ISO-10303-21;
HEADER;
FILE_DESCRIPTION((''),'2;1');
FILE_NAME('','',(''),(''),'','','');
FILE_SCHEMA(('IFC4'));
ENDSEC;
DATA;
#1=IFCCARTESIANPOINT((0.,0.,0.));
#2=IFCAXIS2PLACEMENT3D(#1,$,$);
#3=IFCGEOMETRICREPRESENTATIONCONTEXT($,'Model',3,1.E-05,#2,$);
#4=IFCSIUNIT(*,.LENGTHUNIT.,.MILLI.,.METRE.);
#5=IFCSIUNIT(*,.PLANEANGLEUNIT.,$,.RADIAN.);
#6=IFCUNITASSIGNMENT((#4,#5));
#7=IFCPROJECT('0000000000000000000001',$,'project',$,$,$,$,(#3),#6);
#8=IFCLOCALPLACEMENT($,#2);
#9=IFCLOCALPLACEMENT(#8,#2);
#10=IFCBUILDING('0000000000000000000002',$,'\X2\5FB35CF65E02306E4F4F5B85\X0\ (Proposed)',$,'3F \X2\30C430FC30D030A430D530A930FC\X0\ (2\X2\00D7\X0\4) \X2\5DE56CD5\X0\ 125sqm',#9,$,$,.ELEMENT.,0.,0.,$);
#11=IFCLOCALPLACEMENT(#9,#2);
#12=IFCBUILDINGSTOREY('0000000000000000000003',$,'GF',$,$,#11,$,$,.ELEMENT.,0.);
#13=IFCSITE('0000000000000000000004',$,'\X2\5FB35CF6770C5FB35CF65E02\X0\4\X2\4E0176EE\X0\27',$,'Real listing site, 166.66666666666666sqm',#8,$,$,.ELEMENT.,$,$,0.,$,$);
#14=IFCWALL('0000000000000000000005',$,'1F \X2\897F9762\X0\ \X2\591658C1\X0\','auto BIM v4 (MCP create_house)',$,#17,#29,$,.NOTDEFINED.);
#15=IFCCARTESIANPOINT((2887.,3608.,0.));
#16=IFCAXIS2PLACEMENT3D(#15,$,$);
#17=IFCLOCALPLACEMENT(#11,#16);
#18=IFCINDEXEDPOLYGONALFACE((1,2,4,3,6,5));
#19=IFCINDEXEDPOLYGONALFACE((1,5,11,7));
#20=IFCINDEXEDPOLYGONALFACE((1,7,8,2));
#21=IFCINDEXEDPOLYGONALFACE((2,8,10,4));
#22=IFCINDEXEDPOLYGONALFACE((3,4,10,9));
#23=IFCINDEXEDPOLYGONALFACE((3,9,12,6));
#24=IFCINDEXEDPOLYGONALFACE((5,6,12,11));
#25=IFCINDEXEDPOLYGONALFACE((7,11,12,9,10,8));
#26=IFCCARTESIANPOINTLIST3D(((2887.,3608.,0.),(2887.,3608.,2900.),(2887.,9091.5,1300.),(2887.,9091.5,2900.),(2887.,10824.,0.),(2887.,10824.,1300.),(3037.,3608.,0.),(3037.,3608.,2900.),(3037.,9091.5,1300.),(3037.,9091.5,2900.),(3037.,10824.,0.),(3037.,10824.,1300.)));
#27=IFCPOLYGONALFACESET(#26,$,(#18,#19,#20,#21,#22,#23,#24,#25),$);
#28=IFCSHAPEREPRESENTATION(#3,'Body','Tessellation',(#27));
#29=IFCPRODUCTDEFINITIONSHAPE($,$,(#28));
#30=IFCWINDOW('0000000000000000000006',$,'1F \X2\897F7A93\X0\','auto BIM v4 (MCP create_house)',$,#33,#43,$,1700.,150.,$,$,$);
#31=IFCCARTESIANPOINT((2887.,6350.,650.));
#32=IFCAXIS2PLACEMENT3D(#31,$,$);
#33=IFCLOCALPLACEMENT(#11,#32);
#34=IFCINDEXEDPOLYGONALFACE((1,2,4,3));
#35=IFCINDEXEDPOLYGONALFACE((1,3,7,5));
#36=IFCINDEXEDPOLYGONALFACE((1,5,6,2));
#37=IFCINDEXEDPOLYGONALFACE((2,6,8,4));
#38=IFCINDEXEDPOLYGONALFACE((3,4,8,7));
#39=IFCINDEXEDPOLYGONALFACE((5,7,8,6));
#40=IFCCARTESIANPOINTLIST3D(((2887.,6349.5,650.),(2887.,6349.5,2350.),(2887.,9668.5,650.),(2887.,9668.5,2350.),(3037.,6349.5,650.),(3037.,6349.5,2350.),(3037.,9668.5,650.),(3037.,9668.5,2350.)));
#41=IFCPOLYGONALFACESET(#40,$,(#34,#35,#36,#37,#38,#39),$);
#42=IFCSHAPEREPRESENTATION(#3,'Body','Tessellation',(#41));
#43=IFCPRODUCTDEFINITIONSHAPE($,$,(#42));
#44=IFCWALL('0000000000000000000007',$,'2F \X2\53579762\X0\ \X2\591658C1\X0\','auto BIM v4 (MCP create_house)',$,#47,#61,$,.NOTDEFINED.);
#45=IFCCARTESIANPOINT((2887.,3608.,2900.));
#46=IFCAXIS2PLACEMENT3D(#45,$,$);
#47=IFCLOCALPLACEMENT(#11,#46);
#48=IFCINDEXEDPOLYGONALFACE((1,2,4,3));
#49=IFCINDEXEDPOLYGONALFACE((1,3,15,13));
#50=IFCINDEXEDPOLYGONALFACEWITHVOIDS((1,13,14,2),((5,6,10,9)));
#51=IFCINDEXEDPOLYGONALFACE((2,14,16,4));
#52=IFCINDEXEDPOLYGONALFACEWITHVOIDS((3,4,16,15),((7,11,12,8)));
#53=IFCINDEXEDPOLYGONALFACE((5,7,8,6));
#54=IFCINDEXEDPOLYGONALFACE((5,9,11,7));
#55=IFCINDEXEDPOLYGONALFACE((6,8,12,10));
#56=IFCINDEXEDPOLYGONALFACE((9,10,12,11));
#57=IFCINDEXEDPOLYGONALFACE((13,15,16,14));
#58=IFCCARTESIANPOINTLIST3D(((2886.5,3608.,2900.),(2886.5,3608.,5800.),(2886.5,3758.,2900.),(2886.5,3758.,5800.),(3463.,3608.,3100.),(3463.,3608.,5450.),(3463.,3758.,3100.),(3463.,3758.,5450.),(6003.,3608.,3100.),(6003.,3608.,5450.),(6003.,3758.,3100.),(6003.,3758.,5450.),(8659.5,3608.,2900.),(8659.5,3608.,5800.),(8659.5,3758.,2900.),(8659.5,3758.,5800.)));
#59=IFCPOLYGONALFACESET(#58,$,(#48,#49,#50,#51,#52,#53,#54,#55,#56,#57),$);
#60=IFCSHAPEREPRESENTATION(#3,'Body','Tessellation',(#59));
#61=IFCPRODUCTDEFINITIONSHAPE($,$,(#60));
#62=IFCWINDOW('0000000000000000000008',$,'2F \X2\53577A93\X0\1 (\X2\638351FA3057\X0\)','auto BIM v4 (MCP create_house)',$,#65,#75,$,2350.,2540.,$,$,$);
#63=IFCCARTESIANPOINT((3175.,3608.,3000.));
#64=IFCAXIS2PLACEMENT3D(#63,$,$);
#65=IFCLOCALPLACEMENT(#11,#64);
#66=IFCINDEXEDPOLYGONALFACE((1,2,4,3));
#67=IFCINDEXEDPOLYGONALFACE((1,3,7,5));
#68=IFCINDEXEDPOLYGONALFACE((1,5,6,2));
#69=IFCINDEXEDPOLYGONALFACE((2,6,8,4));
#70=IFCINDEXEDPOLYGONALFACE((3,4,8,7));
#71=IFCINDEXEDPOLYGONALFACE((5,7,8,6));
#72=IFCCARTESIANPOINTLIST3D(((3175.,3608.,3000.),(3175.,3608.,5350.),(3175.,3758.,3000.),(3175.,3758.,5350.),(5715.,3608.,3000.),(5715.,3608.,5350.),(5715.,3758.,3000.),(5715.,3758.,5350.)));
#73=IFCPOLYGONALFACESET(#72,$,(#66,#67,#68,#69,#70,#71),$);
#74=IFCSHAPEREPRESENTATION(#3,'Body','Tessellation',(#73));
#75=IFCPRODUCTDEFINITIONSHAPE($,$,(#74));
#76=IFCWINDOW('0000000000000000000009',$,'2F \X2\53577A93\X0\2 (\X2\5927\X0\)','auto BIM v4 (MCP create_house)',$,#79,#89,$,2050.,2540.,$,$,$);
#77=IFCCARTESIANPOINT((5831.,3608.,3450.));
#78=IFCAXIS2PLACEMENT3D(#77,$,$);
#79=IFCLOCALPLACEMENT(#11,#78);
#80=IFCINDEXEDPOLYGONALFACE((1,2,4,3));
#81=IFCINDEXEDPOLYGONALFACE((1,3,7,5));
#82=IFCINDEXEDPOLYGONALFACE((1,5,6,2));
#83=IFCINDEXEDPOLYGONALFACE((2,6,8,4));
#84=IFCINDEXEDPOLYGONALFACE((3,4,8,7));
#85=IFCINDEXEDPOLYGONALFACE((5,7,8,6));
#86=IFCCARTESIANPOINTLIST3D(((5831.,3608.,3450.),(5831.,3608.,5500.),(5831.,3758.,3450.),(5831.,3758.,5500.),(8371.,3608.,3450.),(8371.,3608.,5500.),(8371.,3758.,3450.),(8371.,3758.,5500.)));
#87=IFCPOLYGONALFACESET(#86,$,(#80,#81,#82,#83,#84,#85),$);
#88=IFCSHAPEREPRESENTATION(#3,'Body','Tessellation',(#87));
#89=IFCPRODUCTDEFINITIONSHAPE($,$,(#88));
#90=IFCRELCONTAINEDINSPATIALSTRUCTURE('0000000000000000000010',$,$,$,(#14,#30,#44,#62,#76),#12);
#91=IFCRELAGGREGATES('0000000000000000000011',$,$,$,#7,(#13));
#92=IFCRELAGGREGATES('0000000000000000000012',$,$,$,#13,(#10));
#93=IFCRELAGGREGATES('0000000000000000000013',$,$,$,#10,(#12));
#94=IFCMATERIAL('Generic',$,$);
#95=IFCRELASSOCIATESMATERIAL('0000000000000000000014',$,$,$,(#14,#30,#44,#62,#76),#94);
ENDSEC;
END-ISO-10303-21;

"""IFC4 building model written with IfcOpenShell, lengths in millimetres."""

from ifc_helpers import new_model, si_unit, frame, frame_2d, origin, place, context, project, spatial, rectangle, extrude, material, element, fill, save


model = new_model("IFC4")

# Units and contexts
model_context = context("Model", 3, precision=1e-05, world=origin())
ifc_project = project(units=[si_unit("LENGTHUNIT", "METRE", prefix="MILLI"), si_unit("PLANEANGLEUNIT", "RADIAN")], contexts=[model_context])

# Site, building, storey
site_placement = place(None, origin())
site = spatial("IfcSite", under=ifc_project, at=site_placement, Name="徳島県徳島市4丁目27", ObjectType="Real listing site, 166.66666666666666sqm", CompositionType="ELEMENT", RefElevation=0.0)
building_placement = place(site_placement, origin())
building = spatial("IfcBuilding", under=site, at=building_placement, Name="徳島市の住宅 (Proposed)", ObjectType="3F ツーバイフォー (2×4) 工法 125sqm", CompositionType="ELEMENT", ElevationOfRefHeight=0.0, ElevationOfTerrain=0.0)
storey_placement = place(building_placement, origin())
storey = spatial("IfcBuildingStorey", under=building, at=storey_placement, Name="GF", CompositionType="ELEMENT", Elevation=0.0)

# Shared definitions
ifc_material = material(Name="Generic")

# Wall, opening, window
wall_1_placement = place(storey_placement, frame((2887.0, 3608.0, 0.0)))
wall_1 = element("IfcWall", 1, at=wall_1_placement, inside=storey, material=ifc_material, Name="1F 西面 外壁", Description="auto BIM v4 (MCP create_house)", PredefinedType="NOTDEFINED", context=model_context, shape_type="SweptSolid", body=[
    extrude(rectangle(XDim=150.0, YDim=7216.0, at=frame_2d((75.0, 3608.0))), frame((2887.0, 3608.0, 0.0)), (0.0, 0.0, 1.0), 2900.0),
])
opening_1_placement = place(storey_placement, frame((2887.0, 6350.0, 650.0)))
opening_1 = element("IfcOpeningElement", 2, at=opening_1_placement, cuts=wall_1, PredefinedType="NOTDEFINED", context=model_context, shape_type="SweptSolid", body=[
    extrude(rectangle(XDim=150.0, YDim=3319.0, at=frame_2d((75.0, 1659.0))), frame((2887.0, 6350.0, 650.0)), (0.0, 0.0, 1.0), 1700.0),
])
window_1_placement = place(storey_placement, frame((2887.0, 6350.0, 650.0)))
window_1 = element("IfcWindow", 3, at=window_1_placement, inside=storey, material=ifc_material, Name="1F 西窓", Description="auto BIM v4 (MCP create_house)", OverallHeight=1700.0, OverallWidth=150.0, context=model_context, shape_type="SweptSolid", body=[
    extrude(rectangle(XDim=150.0, YDim=3319.0, at=frame_2d((75.0, 1659.0))), frame((2887.0, 6350.0, 650.0)), (0.0, 0.0, 1.0), 1700.0),
])
fill(opening_1, window_1)

# Wall, openings, windows
wall_2_placement = place(storey_placement, frame((2887.0, 3608.0, 2900.0)))
wall_2 = element("IfcWall", 4, at=wall_2_placement, inside=storey, material=ifc_material, Name="2F 南面 外壁", Description="auto BIM v4 (MCP create_house)", PredefinedType="NOTDEFINED", context=model_context, shape_type="SweptSolid", body=[
    extrude(rectangle(XDim=5773.0, YDim=150.0, at=frame_2d((2886.0, 75.0))), frame((2887.0, 3608.0, 2900.0)), (0.0, 0.0, 1.0), 2900.0),
])
opening_2_placement = place(storey_placement, frame((3175.0, 3608.0, 3000.0)))
opening_2 = element("IfcOpeningElement", 5, at=opening_2_placement, cuts=wall_2, PredefinedType="NOTDEFINED", context=model_context, shape_type="SweptSolid", body=[
    extrude(rectangle(XDim=2540.0, YDim=150.0, at=frame_2d((1270.0, 75.0))), frame((3175.0, 3608.0, 3000.0)), (0.0, 0.0, 1.0), 2350.0),
])
opening_3_placement = place(storey_placement, frame((5831.0, 3608.0, 3450.0)))
opening_3 = element("IfcOpeningElement", 6, at=opening_3_placement, cuts=wall_2, PredefinedType="NOTDEFINED", context=model_context, shape_type="SweptSolid", body=[
    extrude(rectangle(XDim=2540.0, YDim=150.0, at=frame_2d((1270.0, 75.0))), frame((5831.0, 3608.0, 3450.0)), (0.0, 0.0, 1.0), 2050.0),
])
window_2_placement = place(storey_placement, frame((3175.0, 3608.0, 3000.0)))
window_2 = element("IfcWindow", 7, at=window_2_placement, inside=storey, material=ifc_material, Name="2F 南窓1 (掃出し)", Description="auto BIM v4 (MCP create_house)", OverallHeight=2350.0, OverallWidth=2540.0, context=model_context, shape_type="SweptSolid", body=[
    extrude(rectangle(XDim=2540.0, YDim=150.0, at=frame_2d((1270.0, 75.0))), frame((3175.0, 3608.0, 3000.0)), (0.0, 0.0, 1.0), 2350.0),
])
fill(opening_2, window_2)
window_3_placement = place(storey_placement, frame((5831.0, 3608.0, 3450.0)))
window_3 = element("IfcWindow", 8, at=window_3_placement, inside=storey, material=ifc_material, Name="2F 南窓2 (大)", Description="auto BIM v4 (MCP create_house)", OverallHeight=2050.0, OverallWidth=2540.0, context=model_context, shape_type="SweptSolid", body=[
    extrude(rectangle(XDim=2540.0, YDim=150.0, at=frame_2d((1270.0, 75.0))), frame((5831.0, 3608.0, 3450.0)), (0.0, 0.0, 1.0), 2050.0),
])
fill(opening_3, window_3)

save(model, "model.ifc")
